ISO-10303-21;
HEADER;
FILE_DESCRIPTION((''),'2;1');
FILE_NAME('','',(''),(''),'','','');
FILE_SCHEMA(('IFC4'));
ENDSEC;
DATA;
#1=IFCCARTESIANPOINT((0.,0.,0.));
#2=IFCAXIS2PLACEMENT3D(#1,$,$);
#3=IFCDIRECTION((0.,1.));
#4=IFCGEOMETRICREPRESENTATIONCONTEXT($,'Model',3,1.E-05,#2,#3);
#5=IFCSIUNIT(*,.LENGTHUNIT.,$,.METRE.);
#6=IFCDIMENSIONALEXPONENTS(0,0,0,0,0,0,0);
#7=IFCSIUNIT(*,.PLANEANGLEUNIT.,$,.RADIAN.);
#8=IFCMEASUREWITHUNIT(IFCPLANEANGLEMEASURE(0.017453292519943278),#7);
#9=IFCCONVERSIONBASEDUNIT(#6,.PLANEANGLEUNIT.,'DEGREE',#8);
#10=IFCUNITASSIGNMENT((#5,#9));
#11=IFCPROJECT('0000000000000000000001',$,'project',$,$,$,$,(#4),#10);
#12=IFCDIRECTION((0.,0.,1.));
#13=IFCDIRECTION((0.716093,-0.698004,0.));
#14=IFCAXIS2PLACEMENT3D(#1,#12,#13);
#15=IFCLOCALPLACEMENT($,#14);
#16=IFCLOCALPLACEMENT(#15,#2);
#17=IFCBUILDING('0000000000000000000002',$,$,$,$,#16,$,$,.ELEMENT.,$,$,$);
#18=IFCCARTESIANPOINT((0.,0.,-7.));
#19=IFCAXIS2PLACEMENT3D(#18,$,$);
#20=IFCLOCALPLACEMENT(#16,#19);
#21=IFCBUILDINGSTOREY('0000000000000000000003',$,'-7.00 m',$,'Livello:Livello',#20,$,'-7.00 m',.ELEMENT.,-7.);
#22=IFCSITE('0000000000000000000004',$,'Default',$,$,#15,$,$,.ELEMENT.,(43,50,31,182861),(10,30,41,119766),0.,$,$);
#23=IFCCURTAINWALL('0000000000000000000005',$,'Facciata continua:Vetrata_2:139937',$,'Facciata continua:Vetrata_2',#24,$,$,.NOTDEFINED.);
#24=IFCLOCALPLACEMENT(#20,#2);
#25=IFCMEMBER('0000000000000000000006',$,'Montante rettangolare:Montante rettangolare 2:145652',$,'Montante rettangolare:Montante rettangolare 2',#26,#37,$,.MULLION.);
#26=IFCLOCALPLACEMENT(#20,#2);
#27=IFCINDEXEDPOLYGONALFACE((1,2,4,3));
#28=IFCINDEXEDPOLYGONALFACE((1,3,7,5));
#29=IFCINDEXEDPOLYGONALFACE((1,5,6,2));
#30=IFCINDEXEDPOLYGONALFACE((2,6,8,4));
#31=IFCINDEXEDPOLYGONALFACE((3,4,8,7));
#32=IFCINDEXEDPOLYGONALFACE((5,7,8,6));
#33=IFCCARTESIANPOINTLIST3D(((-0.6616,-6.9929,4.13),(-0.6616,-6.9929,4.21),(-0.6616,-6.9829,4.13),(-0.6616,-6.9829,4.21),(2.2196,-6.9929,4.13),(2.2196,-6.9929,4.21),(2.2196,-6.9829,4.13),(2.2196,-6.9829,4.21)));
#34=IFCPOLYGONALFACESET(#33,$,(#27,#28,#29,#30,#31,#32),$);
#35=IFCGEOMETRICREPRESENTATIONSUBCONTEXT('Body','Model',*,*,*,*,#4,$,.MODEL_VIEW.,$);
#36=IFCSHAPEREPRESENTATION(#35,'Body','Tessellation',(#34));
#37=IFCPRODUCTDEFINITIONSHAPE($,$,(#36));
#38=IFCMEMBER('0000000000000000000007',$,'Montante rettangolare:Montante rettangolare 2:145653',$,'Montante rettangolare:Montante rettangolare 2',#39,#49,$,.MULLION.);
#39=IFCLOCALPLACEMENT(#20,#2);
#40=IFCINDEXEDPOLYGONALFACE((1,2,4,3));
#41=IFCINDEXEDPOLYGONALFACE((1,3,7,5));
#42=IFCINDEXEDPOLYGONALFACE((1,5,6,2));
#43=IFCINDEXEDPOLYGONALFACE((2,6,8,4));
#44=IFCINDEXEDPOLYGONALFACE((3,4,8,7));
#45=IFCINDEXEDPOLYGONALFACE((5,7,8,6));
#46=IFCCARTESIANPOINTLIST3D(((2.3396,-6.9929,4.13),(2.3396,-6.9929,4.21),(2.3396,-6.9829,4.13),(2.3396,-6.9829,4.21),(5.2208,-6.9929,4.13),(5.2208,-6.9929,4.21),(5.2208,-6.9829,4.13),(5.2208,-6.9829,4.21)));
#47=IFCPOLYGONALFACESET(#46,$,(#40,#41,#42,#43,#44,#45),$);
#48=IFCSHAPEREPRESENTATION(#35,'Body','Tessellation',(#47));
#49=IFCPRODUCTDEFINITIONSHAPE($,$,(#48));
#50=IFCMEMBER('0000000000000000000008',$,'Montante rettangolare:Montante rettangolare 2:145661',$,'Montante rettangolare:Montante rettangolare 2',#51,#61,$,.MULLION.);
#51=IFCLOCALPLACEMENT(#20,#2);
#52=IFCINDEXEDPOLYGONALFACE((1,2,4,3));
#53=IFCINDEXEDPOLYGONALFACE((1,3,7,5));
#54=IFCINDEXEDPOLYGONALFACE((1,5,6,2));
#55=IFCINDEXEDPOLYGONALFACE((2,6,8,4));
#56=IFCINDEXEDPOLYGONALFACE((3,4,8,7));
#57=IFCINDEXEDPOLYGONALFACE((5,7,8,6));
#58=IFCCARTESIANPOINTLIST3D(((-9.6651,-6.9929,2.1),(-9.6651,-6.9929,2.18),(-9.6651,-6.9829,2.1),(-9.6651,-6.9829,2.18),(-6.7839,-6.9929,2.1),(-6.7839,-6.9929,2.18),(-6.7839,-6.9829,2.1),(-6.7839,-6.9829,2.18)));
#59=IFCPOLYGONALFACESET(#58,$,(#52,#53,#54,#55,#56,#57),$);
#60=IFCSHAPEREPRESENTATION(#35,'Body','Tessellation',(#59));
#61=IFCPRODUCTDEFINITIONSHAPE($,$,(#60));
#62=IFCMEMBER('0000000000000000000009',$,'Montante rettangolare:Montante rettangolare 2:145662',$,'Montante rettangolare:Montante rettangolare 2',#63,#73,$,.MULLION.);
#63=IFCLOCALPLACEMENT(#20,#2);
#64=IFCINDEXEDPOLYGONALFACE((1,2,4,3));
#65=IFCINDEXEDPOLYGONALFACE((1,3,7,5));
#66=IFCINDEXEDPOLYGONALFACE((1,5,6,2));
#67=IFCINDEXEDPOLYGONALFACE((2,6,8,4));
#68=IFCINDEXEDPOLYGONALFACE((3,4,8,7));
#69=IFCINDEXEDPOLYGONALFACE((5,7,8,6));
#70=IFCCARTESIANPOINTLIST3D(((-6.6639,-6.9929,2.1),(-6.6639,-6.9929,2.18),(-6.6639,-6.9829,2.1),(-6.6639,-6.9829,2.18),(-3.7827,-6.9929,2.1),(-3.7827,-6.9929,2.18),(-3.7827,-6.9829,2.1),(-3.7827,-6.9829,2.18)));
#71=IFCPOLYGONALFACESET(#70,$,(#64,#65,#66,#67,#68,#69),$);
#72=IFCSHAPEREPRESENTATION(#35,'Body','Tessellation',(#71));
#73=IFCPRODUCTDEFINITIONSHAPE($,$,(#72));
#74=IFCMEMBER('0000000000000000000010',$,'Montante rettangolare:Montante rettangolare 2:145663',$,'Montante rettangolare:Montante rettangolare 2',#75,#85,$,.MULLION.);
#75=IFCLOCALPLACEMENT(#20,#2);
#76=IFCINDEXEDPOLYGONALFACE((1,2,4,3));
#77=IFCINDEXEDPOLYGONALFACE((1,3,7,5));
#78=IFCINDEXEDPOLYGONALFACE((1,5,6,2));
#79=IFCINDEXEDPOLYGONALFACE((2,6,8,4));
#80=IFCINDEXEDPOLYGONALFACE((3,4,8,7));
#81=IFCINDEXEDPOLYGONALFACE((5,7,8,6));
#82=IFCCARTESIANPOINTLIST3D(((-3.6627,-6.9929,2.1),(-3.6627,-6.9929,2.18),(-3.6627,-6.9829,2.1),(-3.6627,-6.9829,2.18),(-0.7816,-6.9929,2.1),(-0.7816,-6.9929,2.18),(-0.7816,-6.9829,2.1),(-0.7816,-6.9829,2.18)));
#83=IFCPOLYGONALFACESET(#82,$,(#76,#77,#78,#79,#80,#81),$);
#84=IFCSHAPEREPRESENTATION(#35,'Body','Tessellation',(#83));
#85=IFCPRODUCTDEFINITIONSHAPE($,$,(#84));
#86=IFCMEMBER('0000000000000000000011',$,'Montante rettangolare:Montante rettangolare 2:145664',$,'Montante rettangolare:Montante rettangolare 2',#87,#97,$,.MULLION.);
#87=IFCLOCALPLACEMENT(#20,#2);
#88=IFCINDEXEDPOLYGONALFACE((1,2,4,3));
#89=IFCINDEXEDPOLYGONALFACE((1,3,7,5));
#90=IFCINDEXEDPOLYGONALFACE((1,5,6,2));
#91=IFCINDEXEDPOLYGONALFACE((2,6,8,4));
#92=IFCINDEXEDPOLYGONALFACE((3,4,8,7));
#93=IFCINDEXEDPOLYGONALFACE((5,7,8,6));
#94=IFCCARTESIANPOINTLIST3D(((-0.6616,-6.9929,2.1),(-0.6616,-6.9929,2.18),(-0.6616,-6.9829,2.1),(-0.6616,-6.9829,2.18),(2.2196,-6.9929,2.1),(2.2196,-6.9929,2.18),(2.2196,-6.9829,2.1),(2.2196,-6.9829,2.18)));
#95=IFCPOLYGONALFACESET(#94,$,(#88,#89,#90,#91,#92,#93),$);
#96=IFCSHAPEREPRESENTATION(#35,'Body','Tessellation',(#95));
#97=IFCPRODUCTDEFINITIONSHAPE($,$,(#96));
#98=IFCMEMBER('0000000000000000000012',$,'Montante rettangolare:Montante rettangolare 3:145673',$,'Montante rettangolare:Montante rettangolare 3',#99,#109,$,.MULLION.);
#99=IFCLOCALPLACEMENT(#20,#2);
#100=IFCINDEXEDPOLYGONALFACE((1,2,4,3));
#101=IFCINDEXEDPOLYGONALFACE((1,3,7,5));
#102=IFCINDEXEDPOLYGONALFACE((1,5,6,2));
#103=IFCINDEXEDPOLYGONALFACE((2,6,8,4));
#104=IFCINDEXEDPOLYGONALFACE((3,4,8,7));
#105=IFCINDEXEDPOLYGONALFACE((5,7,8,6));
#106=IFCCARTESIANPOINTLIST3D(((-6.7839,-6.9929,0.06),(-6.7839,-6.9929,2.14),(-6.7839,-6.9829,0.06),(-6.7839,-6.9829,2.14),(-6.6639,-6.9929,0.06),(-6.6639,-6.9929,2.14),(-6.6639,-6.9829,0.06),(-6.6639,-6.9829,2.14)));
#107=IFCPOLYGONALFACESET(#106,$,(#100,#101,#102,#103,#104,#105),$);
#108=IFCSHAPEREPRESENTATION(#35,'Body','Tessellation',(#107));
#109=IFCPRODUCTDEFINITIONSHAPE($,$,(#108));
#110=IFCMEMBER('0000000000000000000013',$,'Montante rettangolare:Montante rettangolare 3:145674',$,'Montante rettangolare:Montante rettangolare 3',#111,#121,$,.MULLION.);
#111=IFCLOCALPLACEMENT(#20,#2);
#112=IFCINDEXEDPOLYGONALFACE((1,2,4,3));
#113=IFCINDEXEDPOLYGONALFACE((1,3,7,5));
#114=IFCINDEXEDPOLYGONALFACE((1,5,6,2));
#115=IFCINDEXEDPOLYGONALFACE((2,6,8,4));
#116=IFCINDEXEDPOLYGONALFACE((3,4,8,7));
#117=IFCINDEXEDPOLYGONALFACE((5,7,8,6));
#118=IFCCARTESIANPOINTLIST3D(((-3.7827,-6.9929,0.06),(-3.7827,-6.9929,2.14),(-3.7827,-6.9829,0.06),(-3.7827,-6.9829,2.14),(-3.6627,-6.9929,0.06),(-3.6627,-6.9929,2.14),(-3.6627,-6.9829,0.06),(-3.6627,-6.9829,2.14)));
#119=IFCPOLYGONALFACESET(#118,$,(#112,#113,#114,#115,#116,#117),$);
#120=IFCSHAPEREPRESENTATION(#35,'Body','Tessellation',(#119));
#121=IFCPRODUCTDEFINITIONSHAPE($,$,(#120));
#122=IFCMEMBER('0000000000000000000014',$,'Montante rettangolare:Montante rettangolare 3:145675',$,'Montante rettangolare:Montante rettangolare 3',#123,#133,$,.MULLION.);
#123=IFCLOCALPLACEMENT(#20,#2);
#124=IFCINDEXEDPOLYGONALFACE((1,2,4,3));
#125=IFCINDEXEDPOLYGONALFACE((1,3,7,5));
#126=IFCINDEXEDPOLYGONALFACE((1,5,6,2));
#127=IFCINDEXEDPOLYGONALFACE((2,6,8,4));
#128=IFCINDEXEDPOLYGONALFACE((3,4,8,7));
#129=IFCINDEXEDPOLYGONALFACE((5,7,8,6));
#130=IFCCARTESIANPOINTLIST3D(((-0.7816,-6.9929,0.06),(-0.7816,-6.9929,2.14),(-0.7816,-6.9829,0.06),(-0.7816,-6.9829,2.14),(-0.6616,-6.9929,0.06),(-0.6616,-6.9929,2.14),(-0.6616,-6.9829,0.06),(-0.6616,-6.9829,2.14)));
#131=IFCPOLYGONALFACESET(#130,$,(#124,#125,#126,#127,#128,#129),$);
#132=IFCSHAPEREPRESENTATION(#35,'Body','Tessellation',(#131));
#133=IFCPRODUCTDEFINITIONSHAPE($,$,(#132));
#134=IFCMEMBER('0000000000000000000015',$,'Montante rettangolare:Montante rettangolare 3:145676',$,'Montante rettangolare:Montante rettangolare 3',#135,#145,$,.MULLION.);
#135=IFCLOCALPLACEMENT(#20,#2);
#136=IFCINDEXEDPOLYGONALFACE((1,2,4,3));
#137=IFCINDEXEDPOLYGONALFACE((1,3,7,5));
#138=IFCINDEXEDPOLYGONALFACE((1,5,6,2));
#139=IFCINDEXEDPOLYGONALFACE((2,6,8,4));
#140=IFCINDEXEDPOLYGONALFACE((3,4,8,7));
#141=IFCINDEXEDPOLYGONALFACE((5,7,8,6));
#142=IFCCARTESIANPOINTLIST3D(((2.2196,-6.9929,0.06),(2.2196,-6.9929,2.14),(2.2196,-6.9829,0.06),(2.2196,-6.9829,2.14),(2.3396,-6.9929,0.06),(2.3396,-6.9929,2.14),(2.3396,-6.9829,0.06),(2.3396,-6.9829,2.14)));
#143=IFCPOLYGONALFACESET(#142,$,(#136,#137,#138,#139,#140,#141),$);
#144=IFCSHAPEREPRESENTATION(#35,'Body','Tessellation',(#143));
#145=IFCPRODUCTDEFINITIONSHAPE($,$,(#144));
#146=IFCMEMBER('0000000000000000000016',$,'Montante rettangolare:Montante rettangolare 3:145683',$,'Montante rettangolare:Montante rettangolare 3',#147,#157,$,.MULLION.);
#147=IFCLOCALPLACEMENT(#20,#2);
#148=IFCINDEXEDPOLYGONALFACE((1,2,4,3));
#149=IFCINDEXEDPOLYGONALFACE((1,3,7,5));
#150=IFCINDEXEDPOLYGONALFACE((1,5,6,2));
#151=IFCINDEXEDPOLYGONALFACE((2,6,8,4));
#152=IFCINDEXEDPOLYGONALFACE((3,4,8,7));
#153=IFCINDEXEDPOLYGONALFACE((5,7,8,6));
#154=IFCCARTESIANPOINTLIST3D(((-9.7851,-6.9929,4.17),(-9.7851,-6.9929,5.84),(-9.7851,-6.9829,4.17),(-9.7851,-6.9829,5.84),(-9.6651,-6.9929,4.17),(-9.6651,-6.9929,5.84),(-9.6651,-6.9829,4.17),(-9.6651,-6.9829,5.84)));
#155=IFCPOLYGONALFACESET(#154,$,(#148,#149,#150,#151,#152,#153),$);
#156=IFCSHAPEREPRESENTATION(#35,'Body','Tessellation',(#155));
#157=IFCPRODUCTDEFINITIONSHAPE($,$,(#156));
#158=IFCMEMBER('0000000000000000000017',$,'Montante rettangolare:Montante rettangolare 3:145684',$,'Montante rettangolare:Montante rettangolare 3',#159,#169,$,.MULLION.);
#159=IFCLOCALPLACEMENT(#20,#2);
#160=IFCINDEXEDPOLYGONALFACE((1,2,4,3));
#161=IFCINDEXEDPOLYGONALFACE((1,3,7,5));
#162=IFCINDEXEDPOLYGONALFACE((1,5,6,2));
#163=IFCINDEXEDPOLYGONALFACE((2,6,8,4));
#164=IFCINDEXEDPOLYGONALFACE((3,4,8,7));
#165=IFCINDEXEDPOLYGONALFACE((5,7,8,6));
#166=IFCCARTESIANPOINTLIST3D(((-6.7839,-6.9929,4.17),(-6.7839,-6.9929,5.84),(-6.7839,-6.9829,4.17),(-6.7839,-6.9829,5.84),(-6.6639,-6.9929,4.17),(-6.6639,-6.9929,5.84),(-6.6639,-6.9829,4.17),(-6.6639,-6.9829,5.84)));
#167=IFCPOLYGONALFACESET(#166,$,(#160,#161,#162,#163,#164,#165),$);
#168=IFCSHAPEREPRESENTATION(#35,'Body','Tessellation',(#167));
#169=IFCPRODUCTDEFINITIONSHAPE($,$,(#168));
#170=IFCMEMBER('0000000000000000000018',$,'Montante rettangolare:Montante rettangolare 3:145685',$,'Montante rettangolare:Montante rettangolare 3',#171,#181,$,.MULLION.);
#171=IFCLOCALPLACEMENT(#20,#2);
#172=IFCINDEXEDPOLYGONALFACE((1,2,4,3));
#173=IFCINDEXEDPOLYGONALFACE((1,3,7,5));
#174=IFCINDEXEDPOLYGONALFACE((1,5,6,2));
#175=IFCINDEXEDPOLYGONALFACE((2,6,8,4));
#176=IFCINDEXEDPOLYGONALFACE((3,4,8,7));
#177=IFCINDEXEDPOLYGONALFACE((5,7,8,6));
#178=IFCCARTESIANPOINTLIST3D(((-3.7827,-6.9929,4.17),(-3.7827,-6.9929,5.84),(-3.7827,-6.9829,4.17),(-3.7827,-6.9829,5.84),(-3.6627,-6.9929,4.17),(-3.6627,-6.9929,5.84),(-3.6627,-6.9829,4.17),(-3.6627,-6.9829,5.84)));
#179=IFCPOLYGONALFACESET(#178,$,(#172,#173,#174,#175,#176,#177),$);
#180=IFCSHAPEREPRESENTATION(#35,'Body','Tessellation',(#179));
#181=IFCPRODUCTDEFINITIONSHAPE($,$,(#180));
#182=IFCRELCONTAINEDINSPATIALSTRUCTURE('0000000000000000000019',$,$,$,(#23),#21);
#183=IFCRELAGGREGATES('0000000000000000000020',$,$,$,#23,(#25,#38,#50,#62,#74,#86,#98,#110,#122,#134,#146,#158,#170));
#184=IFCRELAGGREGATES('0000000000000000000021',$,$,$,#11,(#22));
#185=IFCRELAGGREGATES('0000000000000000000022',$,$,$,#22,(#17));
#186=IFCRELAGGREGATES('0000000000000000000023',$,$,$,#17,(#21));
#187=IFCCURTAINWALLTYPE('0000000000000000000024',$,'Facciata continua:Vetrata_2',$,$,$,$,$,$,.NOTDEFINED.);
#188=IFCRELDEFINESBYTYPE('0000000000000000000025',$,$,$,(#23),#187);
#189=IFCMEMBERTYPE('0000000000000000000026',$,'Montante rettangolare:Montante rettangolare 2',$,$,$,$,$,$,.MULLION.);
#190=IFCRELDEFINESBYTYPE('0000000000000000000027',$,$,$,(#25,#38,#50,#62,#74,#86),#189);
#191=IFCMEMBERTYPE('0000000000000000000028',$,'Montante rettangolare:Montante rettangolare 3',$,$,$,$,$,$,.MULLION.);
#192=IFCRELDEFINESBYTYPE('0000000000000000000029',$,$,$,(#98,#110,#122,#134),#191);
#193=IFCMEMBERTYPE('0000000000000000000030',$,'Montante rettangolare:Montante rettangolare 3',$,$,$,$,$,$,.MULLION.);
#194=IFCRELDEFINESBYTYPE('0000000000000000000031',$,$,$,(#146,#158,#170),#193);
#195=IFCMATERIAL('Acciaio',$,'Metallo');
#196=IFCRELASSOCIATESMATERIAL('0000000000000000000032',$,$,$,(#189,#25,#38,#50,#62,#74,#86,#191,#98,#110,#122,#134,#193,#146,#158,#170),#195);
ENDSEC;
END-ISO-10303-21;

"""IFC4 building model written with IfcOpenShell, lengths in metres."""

from ifc_helpers import new_model, entity, si_unit, converted_unit, direction, frame, origin, place, context, subcontext, project, spatial, indexed_curve, outline, extrude, source, transform, mapped, material, type_object, type_shapes, element, aggregate, save


model = new_model("IFC4")

# Units and contexts
model_context = context("Model", 3, precision=1e-05, world=origin(), true_north=direction((0.0, 1.0)))
body_context = subcontext(model_context, "Body", "Model", "MODEL_VIEW")
ifc_project = project(units=[si_unit("LENGTHUNIT", "METRE"), converted_unit("PLANEANGLEUNIT", "DEGREE", entity("IfcPlaneAngleMeasure", 0.017453292519943278), si_unit("PLANEANGLEUNIT", "RADIAN"), dimensions=[0, 0, 0, 0, 0, 0, 0])], contexts=[model_context])

# Site, building, storey
site_placement = place(None, frame((0.0, 0.0, 0.0), z_axis=(0.0, 0.0, 1.0), x_axis=(0.716093, -0.698004, 0.0)))
site = spatial("IfcSite", under=ifc_project, at=site_placement, Name="Default", CompositionType="ELEMENT", RefLatitude=(43, 50, 31, 182861), RefLongitude=(10, 30, 41, 119766), RefElevation=0.0)
building_placement = place(site_placement, origin())
building = spatial("IfcBuilding", under=site, at=building_placement, CompositionType="ELEMENT")
storey_placement = place(building_placement, frame((0.0, 0.0, -7.0)))
storey = spatial("IfcBuildingStorey", under=building, at=storey_placement, Name="-7.00 m", ObjectType="Livello:Livello", LongName="-7.00 m", CompositionType="ELEMENT", Elevation=-7.0)

# Curtain wall, members
curtain_wall_type = type_object("IfcCurtainWallType", Name="Facciata continua:Vetrata_2", PredefinedType="NOTDEFINED")
curtain_wall_placement = place(storey_placement, frame((0.0, 0.0, 7.0)))
curtain_wall = element("IfcCurtainWall", 1, at=curtain_wall_placement, inside=storey, type_object=curtain_wall_type, Name="Facciata continua:Vetrata_2:139937", ObjectType="Facciata continua:Vetrata_2", PredefinedType="NOTDEFINED")
ifc_material = material(Name="Acciaio", Category="Metallo")
member_type_1 = type_object("IfcMemberType", Name="Montante rettangolare:Montante rettangolare 2", PredefinedType="MULLION", material=ifc_material)
shared_shape_1 = source(origin(), body_context, "Body", "SweptSolid", [
    extrude(outline(indexed_curve([(-0.04, -0.005), (0.04, -0.005), (0.04, 0.005), (-0.04, 0.005), (-0.04, -0.005)], self_intersect=False)), frame((0.0, 0.01, -2.8812), z_axis=(0.0, 0.0, 1.0), x_axis=(-1.0, 0.0, 0.0)), (0.0, 0.0, 1.0), 2.8812),
])
type_shapes(member_type_1, [shared_shape_1])
member_1_placement = place(curtain_wall_placement, frame((2.2196, -6.9779, -2.83), z_axis=(1.0, 0.0, 0.0), x_axis=(0.0, 0.0, 1.0)))
member_1 = element("IfcMember", 2, at=member_1_placement, type_object=member_type_1, material=ifc_material, Name="Montante rettangolare:Montante rettangolare 2:145652", ObjectType="Montante rettangolare:Montante rettangolare 2", PredefinedType="MULLION", context=body_context, shape_type="MappedRepresentation", body=[
    mapped(shared_shape_1, transform((0.0, 0.0, 0.0), scale=1.0)),
])
member_2_placement = place(curtain_wall_placement, frame((5.2208, -6.9779, -2.83), z_axis=(1.0, 0.0, 0.0), x_axis=(0.0, 0.0, 1.0)))
member_2 = element("IfcMember", 3, at=member_2_placement, type_object=member_type_1, material=ifc_material, Name="Montante rettangolare:Montante rettangolare 2:145653", ObjectType="Montante rettangolare:Montante rettangolare 2", PredefinedType="MULLION", context=body_context, shape_type="MappedRepresentation", body=[
    mapped(shared_shape_1, transform((0.0, 0.0, 0.0), scale=1.0)),
])
member_3_placement = place(curtain_wall_placement, frame((-6.7839, -6.9779, -4.86), z_axis=(1.0, 0.0, 0.0), x_axis=(0.0, 0.0, 1.0)))
member_3 = element("IfcMember", 4, at=member_3_placement, type_object=member_type_1, material=ifc_material, Name="Montante rettangolare:Montante rettangolare 2:145661", ObjectType="Montante rettangolare:Montante rettangolare 2", PredefinedType="MULLION", context=body_context, shape_type="MappedRepresentation", body=[
    mapped(shared_shape_1, transform((0.0, 0.0, 0.0), scale=1.0)),
])
member_4_placement = place(curtain_wall_placement, frame((-3.7827, -6.9779, -4.86), z_axis=(1.0, 0.0, 0.0), x_axis=(0.0, 0.0, 1.0)))
member_4 = element("IfcMember", 5, at=member_4_placement, type_object=member_type_1, material=ifc_material, Name="Montante rettangolare:Montante rettangolare 2:145662", ObjectType="Montante rettangolare:Montante rettangolare 2", PredefinedType="MULLION", context=body_context, shape_type="MappedRepresentation", body=[
    mapped(shared_shape_1, transform((0.0, 0.0, 0.0), scale=1.0)),
])
member_5_placement = place(curtain_wall_placement, frame((-0.7816, -6.9779, -4.86), z_axis=(1.0, 0.0, 0.0), x_axis=(0.0, 0.0, 1.0)))
member_5 = element("IfcMember", 6, at=member_5_placement, type_object=member_type_1, material=ifc_material, Name="Montante rettangolare:Montante rettangolare 2:145663", ObjectType="Montante rettangolare:Montante rettangolare 2", PredefinedType="MULLION", context=body_context, shape_type="MappedRepresentation", body=[
    mapped(shared_shape_1, transform((0.0, 0.0, 0.0), scale=1.0)),
])
member_6_placement = place(curtain_wall_placement, frame((2.2196, -6.9779, -4.86), z_axis=(1.0, 0.0, 0.0), x_axis=(0.0, 0.0, 1.0)))
member_6 = element("IfcMember", 7, at=member_6_placement, type_object=member_type_1, material=ifc_material, Name="Montante rettangolare:Montante rettangolare 2:145664", ObjectType="Montante rettangolare:Montante rettangolare 2", PredefinedType="MULLION", context=body_context, shape_type="MappedRepresentation", body=[
    mapped(shared_shape_1, transform((0.0, 0.0, 0.0), scale=1.0)),
])
member_type_2 = type_object("IfcMemberType", Name="Montante rettangolare:Montante rettangolare 3", PredefinedType="MULLION", material=ifc_material)
shared_shape_2 = source(origin(), body_context, "Body", "SweptSolid", [
    extrude(outline(indexed_curve([(-0.06, -0.005), (0.06, -0.005), (0.06, 0.005), (-0.06, 0.005), (-0.06, -0.005)], self_intersect=False)), frame((0.0, 0.01, -2.08), z_axis=(0.0, 0.0, 1.0), x_axis=(-1.0, 0.0, 0.0)), (0.0, 0.0, 1.0), 2.08),
])
type_shapes(member_type_2, [shared_shape_2])
member_7_placement = place(curtain_wall_placement, frame((-6.7239, -6.9779, -6.94), z_axis=(0.0, 0.0, -1.0), x_axis=(1.0, 0.0, 0.0)))
member_7 = element("IfcMember", 8, at=member_7_placement, type_object=member_type_2, material=ifc_material, Name="Montante rettangolare:Montante rettangolare 3:145673", ObjectType="Montante rettangolare:Montante rettangolare 3", PredefinedType="MULLION", context=body_context, shape_type="MappedRepresentation", body=[
    mapped(shared_shape_2, transform((0.0, 0.0, 0.0), scale=1.0)),
])
member_8_placement = place(curtain_wall_placement, frame((-3.7227, -6.9779, -6.94), z_axis=(0.0, 0.0, -1.0), x_axis=(1.0, 0.0, 0.0)))
member_8 = element("IfcMember", 9, at=member_8_placement, type_object=member_type_2, material=ifc_material, Name="Montante rettangolare:Montante rettangolare 3:145674", ObjectType="Montante rettangolare:Montante rettangolare 3", PredefinedType="MULLION", context=body_context, shape_type="MappedRepresentation", body=[
    mapped(shared_shape_2, transform((0.0, 0.0, 0.0), scale=1.0)),
])
member_9_placement = place(curtain_wall_placement, frame((-0.7216, -6.9779, -6.94), z_axis=(0.0, 0.0, -1.0), x_axis=(1.0, 0.0, 0.0)))
member_9 = element("IfcMember", 10, at=member_9_placement, type_object=member_type_2, material=ifc_material, Name="Montante rettangolare:Montante rettangolare 3:145675", ObjectType="Montante rettangolare:Montante rettangolare 3", PredefinedType="MULLION", context=body_context, shape_type="MappedRepresentation", body=[
    mapped(shared_shape_2, transform((0.0, 0.0, 0.0), scale=1.0)),
])
member_10_placement = place(curtain_wall_placement, frame((2.2796, -6.9779, -6.94), z_axis=(0.0, 0.0, -1.0), x_axis=(1.0, 0.0, 0.0)))
member_10 = element("IfcMember", 11, at=member_10_placement, type_object=member_type_2, material=ifc_material, Name="Montante rettangolare:Montante rettangolare 3:145676", ObjectType="Montante rettangolare:Montante rettangolare 3", PredefinedType="MULLION", context=body_context, shape_type="MappedRepresentation", body=[
    mapped(shared_shape_2, transform((0.0, 0.0, 0.0), scale=1.0)),
])
member_type_3 = type_object("IfcMemberType", Name="Montante rettangolare:Montante rettangolare 3", PredefinedType="MULLION", material=ifc_material)
shared_shape_3 = source(origin(), body_context, "Body", "SweptSolid", [
    extrude(outline(indexed_curve([(-0.06, -0.005), (0.06, -0.005), (0.06, 0.005), (-0.06, 0.005), (-0.06, -0.005)], self_intersect=False)), frame((0.0, 0.01, -1.67), z_axis=(0.0, 0.0, 1.0), x_axis=(-1.0, 0.0, 0.0)), (0.0, 0.0, 1.0), 1.67),
])
type_shapes(member_type_3, [shared_shape_3])
member_11_placement = place(curtain_wall_placement, frame((-9.7251, -6.9779, -2.83), z_axis=(0.0, 0.0, -1.0), x_axis=(1.0, 0.0, 0.0)))
member_11 = element("IfcMember", 12, at=member_11_placement, type_object=member_type_3, material=ifc_material, Name="Montante rettangolare:Montante rettangolare 3:145683", ObjectType="Montante rettangolare:Montante rettangolare 3", PredefinedType="MULLION", context=body_context, shape_type="MappedRepresentation", body=[
    mapped(shared_shape_3, transform((0.0, 0.0, 0.0), scale=1.0)),
])
member_12_placement = place(curtain_wall_placement, frame((-6.7239, -6.9779, -2.83), z_axis=(0.0, 0.0, -1.0), x_axis=(1.0, 0.0, 0.0)))
member_12 = element("IfcMember", 13, at=member_12_placement, type_object=member_type_3, material=ifc_material, Name="Montante rettangolare:Montante rettangolare 3:145684", ObjectType="Montante rettangolare:Montante rettangolare 3", PredefinedType="MULLION", context=body_context, shape_type="MappedRepresentation", body=[
    mapped(shared_shape_3, transform((0.0, 0.0, 0.0), scale=1.0)),
])
member_13_placement = place(curtain_wall_placement, frame((-3.7227, -6.9779, -2.83), z_axis=(0.0, 0.0, -1.0), x_axis=(1.0, 0.0, 0.0)))
member_13 = element("IfcMember", 14, at=member_13_placement, type_object=member_type_3, material=ifc_material, Name="Montante rettangolare:Montante rettangolare 3:145685", ObjectType="Montante rettangolare:Montante rettangolare 3", PredefinedType="MULLION", context=body_context, shape_type="MappedRepresentation", body=[
    mapped(shared_shape_3, transform((0.0, 0.0, 0.0), scale=1.0)),
])
aggregate(curtain_wall, [member_1, member_2, member_3, member_4, member_5, member_6, member_7, member_8, member_9, member_10, member_11, member_12, member_13])

save(model, "model.ifc")
